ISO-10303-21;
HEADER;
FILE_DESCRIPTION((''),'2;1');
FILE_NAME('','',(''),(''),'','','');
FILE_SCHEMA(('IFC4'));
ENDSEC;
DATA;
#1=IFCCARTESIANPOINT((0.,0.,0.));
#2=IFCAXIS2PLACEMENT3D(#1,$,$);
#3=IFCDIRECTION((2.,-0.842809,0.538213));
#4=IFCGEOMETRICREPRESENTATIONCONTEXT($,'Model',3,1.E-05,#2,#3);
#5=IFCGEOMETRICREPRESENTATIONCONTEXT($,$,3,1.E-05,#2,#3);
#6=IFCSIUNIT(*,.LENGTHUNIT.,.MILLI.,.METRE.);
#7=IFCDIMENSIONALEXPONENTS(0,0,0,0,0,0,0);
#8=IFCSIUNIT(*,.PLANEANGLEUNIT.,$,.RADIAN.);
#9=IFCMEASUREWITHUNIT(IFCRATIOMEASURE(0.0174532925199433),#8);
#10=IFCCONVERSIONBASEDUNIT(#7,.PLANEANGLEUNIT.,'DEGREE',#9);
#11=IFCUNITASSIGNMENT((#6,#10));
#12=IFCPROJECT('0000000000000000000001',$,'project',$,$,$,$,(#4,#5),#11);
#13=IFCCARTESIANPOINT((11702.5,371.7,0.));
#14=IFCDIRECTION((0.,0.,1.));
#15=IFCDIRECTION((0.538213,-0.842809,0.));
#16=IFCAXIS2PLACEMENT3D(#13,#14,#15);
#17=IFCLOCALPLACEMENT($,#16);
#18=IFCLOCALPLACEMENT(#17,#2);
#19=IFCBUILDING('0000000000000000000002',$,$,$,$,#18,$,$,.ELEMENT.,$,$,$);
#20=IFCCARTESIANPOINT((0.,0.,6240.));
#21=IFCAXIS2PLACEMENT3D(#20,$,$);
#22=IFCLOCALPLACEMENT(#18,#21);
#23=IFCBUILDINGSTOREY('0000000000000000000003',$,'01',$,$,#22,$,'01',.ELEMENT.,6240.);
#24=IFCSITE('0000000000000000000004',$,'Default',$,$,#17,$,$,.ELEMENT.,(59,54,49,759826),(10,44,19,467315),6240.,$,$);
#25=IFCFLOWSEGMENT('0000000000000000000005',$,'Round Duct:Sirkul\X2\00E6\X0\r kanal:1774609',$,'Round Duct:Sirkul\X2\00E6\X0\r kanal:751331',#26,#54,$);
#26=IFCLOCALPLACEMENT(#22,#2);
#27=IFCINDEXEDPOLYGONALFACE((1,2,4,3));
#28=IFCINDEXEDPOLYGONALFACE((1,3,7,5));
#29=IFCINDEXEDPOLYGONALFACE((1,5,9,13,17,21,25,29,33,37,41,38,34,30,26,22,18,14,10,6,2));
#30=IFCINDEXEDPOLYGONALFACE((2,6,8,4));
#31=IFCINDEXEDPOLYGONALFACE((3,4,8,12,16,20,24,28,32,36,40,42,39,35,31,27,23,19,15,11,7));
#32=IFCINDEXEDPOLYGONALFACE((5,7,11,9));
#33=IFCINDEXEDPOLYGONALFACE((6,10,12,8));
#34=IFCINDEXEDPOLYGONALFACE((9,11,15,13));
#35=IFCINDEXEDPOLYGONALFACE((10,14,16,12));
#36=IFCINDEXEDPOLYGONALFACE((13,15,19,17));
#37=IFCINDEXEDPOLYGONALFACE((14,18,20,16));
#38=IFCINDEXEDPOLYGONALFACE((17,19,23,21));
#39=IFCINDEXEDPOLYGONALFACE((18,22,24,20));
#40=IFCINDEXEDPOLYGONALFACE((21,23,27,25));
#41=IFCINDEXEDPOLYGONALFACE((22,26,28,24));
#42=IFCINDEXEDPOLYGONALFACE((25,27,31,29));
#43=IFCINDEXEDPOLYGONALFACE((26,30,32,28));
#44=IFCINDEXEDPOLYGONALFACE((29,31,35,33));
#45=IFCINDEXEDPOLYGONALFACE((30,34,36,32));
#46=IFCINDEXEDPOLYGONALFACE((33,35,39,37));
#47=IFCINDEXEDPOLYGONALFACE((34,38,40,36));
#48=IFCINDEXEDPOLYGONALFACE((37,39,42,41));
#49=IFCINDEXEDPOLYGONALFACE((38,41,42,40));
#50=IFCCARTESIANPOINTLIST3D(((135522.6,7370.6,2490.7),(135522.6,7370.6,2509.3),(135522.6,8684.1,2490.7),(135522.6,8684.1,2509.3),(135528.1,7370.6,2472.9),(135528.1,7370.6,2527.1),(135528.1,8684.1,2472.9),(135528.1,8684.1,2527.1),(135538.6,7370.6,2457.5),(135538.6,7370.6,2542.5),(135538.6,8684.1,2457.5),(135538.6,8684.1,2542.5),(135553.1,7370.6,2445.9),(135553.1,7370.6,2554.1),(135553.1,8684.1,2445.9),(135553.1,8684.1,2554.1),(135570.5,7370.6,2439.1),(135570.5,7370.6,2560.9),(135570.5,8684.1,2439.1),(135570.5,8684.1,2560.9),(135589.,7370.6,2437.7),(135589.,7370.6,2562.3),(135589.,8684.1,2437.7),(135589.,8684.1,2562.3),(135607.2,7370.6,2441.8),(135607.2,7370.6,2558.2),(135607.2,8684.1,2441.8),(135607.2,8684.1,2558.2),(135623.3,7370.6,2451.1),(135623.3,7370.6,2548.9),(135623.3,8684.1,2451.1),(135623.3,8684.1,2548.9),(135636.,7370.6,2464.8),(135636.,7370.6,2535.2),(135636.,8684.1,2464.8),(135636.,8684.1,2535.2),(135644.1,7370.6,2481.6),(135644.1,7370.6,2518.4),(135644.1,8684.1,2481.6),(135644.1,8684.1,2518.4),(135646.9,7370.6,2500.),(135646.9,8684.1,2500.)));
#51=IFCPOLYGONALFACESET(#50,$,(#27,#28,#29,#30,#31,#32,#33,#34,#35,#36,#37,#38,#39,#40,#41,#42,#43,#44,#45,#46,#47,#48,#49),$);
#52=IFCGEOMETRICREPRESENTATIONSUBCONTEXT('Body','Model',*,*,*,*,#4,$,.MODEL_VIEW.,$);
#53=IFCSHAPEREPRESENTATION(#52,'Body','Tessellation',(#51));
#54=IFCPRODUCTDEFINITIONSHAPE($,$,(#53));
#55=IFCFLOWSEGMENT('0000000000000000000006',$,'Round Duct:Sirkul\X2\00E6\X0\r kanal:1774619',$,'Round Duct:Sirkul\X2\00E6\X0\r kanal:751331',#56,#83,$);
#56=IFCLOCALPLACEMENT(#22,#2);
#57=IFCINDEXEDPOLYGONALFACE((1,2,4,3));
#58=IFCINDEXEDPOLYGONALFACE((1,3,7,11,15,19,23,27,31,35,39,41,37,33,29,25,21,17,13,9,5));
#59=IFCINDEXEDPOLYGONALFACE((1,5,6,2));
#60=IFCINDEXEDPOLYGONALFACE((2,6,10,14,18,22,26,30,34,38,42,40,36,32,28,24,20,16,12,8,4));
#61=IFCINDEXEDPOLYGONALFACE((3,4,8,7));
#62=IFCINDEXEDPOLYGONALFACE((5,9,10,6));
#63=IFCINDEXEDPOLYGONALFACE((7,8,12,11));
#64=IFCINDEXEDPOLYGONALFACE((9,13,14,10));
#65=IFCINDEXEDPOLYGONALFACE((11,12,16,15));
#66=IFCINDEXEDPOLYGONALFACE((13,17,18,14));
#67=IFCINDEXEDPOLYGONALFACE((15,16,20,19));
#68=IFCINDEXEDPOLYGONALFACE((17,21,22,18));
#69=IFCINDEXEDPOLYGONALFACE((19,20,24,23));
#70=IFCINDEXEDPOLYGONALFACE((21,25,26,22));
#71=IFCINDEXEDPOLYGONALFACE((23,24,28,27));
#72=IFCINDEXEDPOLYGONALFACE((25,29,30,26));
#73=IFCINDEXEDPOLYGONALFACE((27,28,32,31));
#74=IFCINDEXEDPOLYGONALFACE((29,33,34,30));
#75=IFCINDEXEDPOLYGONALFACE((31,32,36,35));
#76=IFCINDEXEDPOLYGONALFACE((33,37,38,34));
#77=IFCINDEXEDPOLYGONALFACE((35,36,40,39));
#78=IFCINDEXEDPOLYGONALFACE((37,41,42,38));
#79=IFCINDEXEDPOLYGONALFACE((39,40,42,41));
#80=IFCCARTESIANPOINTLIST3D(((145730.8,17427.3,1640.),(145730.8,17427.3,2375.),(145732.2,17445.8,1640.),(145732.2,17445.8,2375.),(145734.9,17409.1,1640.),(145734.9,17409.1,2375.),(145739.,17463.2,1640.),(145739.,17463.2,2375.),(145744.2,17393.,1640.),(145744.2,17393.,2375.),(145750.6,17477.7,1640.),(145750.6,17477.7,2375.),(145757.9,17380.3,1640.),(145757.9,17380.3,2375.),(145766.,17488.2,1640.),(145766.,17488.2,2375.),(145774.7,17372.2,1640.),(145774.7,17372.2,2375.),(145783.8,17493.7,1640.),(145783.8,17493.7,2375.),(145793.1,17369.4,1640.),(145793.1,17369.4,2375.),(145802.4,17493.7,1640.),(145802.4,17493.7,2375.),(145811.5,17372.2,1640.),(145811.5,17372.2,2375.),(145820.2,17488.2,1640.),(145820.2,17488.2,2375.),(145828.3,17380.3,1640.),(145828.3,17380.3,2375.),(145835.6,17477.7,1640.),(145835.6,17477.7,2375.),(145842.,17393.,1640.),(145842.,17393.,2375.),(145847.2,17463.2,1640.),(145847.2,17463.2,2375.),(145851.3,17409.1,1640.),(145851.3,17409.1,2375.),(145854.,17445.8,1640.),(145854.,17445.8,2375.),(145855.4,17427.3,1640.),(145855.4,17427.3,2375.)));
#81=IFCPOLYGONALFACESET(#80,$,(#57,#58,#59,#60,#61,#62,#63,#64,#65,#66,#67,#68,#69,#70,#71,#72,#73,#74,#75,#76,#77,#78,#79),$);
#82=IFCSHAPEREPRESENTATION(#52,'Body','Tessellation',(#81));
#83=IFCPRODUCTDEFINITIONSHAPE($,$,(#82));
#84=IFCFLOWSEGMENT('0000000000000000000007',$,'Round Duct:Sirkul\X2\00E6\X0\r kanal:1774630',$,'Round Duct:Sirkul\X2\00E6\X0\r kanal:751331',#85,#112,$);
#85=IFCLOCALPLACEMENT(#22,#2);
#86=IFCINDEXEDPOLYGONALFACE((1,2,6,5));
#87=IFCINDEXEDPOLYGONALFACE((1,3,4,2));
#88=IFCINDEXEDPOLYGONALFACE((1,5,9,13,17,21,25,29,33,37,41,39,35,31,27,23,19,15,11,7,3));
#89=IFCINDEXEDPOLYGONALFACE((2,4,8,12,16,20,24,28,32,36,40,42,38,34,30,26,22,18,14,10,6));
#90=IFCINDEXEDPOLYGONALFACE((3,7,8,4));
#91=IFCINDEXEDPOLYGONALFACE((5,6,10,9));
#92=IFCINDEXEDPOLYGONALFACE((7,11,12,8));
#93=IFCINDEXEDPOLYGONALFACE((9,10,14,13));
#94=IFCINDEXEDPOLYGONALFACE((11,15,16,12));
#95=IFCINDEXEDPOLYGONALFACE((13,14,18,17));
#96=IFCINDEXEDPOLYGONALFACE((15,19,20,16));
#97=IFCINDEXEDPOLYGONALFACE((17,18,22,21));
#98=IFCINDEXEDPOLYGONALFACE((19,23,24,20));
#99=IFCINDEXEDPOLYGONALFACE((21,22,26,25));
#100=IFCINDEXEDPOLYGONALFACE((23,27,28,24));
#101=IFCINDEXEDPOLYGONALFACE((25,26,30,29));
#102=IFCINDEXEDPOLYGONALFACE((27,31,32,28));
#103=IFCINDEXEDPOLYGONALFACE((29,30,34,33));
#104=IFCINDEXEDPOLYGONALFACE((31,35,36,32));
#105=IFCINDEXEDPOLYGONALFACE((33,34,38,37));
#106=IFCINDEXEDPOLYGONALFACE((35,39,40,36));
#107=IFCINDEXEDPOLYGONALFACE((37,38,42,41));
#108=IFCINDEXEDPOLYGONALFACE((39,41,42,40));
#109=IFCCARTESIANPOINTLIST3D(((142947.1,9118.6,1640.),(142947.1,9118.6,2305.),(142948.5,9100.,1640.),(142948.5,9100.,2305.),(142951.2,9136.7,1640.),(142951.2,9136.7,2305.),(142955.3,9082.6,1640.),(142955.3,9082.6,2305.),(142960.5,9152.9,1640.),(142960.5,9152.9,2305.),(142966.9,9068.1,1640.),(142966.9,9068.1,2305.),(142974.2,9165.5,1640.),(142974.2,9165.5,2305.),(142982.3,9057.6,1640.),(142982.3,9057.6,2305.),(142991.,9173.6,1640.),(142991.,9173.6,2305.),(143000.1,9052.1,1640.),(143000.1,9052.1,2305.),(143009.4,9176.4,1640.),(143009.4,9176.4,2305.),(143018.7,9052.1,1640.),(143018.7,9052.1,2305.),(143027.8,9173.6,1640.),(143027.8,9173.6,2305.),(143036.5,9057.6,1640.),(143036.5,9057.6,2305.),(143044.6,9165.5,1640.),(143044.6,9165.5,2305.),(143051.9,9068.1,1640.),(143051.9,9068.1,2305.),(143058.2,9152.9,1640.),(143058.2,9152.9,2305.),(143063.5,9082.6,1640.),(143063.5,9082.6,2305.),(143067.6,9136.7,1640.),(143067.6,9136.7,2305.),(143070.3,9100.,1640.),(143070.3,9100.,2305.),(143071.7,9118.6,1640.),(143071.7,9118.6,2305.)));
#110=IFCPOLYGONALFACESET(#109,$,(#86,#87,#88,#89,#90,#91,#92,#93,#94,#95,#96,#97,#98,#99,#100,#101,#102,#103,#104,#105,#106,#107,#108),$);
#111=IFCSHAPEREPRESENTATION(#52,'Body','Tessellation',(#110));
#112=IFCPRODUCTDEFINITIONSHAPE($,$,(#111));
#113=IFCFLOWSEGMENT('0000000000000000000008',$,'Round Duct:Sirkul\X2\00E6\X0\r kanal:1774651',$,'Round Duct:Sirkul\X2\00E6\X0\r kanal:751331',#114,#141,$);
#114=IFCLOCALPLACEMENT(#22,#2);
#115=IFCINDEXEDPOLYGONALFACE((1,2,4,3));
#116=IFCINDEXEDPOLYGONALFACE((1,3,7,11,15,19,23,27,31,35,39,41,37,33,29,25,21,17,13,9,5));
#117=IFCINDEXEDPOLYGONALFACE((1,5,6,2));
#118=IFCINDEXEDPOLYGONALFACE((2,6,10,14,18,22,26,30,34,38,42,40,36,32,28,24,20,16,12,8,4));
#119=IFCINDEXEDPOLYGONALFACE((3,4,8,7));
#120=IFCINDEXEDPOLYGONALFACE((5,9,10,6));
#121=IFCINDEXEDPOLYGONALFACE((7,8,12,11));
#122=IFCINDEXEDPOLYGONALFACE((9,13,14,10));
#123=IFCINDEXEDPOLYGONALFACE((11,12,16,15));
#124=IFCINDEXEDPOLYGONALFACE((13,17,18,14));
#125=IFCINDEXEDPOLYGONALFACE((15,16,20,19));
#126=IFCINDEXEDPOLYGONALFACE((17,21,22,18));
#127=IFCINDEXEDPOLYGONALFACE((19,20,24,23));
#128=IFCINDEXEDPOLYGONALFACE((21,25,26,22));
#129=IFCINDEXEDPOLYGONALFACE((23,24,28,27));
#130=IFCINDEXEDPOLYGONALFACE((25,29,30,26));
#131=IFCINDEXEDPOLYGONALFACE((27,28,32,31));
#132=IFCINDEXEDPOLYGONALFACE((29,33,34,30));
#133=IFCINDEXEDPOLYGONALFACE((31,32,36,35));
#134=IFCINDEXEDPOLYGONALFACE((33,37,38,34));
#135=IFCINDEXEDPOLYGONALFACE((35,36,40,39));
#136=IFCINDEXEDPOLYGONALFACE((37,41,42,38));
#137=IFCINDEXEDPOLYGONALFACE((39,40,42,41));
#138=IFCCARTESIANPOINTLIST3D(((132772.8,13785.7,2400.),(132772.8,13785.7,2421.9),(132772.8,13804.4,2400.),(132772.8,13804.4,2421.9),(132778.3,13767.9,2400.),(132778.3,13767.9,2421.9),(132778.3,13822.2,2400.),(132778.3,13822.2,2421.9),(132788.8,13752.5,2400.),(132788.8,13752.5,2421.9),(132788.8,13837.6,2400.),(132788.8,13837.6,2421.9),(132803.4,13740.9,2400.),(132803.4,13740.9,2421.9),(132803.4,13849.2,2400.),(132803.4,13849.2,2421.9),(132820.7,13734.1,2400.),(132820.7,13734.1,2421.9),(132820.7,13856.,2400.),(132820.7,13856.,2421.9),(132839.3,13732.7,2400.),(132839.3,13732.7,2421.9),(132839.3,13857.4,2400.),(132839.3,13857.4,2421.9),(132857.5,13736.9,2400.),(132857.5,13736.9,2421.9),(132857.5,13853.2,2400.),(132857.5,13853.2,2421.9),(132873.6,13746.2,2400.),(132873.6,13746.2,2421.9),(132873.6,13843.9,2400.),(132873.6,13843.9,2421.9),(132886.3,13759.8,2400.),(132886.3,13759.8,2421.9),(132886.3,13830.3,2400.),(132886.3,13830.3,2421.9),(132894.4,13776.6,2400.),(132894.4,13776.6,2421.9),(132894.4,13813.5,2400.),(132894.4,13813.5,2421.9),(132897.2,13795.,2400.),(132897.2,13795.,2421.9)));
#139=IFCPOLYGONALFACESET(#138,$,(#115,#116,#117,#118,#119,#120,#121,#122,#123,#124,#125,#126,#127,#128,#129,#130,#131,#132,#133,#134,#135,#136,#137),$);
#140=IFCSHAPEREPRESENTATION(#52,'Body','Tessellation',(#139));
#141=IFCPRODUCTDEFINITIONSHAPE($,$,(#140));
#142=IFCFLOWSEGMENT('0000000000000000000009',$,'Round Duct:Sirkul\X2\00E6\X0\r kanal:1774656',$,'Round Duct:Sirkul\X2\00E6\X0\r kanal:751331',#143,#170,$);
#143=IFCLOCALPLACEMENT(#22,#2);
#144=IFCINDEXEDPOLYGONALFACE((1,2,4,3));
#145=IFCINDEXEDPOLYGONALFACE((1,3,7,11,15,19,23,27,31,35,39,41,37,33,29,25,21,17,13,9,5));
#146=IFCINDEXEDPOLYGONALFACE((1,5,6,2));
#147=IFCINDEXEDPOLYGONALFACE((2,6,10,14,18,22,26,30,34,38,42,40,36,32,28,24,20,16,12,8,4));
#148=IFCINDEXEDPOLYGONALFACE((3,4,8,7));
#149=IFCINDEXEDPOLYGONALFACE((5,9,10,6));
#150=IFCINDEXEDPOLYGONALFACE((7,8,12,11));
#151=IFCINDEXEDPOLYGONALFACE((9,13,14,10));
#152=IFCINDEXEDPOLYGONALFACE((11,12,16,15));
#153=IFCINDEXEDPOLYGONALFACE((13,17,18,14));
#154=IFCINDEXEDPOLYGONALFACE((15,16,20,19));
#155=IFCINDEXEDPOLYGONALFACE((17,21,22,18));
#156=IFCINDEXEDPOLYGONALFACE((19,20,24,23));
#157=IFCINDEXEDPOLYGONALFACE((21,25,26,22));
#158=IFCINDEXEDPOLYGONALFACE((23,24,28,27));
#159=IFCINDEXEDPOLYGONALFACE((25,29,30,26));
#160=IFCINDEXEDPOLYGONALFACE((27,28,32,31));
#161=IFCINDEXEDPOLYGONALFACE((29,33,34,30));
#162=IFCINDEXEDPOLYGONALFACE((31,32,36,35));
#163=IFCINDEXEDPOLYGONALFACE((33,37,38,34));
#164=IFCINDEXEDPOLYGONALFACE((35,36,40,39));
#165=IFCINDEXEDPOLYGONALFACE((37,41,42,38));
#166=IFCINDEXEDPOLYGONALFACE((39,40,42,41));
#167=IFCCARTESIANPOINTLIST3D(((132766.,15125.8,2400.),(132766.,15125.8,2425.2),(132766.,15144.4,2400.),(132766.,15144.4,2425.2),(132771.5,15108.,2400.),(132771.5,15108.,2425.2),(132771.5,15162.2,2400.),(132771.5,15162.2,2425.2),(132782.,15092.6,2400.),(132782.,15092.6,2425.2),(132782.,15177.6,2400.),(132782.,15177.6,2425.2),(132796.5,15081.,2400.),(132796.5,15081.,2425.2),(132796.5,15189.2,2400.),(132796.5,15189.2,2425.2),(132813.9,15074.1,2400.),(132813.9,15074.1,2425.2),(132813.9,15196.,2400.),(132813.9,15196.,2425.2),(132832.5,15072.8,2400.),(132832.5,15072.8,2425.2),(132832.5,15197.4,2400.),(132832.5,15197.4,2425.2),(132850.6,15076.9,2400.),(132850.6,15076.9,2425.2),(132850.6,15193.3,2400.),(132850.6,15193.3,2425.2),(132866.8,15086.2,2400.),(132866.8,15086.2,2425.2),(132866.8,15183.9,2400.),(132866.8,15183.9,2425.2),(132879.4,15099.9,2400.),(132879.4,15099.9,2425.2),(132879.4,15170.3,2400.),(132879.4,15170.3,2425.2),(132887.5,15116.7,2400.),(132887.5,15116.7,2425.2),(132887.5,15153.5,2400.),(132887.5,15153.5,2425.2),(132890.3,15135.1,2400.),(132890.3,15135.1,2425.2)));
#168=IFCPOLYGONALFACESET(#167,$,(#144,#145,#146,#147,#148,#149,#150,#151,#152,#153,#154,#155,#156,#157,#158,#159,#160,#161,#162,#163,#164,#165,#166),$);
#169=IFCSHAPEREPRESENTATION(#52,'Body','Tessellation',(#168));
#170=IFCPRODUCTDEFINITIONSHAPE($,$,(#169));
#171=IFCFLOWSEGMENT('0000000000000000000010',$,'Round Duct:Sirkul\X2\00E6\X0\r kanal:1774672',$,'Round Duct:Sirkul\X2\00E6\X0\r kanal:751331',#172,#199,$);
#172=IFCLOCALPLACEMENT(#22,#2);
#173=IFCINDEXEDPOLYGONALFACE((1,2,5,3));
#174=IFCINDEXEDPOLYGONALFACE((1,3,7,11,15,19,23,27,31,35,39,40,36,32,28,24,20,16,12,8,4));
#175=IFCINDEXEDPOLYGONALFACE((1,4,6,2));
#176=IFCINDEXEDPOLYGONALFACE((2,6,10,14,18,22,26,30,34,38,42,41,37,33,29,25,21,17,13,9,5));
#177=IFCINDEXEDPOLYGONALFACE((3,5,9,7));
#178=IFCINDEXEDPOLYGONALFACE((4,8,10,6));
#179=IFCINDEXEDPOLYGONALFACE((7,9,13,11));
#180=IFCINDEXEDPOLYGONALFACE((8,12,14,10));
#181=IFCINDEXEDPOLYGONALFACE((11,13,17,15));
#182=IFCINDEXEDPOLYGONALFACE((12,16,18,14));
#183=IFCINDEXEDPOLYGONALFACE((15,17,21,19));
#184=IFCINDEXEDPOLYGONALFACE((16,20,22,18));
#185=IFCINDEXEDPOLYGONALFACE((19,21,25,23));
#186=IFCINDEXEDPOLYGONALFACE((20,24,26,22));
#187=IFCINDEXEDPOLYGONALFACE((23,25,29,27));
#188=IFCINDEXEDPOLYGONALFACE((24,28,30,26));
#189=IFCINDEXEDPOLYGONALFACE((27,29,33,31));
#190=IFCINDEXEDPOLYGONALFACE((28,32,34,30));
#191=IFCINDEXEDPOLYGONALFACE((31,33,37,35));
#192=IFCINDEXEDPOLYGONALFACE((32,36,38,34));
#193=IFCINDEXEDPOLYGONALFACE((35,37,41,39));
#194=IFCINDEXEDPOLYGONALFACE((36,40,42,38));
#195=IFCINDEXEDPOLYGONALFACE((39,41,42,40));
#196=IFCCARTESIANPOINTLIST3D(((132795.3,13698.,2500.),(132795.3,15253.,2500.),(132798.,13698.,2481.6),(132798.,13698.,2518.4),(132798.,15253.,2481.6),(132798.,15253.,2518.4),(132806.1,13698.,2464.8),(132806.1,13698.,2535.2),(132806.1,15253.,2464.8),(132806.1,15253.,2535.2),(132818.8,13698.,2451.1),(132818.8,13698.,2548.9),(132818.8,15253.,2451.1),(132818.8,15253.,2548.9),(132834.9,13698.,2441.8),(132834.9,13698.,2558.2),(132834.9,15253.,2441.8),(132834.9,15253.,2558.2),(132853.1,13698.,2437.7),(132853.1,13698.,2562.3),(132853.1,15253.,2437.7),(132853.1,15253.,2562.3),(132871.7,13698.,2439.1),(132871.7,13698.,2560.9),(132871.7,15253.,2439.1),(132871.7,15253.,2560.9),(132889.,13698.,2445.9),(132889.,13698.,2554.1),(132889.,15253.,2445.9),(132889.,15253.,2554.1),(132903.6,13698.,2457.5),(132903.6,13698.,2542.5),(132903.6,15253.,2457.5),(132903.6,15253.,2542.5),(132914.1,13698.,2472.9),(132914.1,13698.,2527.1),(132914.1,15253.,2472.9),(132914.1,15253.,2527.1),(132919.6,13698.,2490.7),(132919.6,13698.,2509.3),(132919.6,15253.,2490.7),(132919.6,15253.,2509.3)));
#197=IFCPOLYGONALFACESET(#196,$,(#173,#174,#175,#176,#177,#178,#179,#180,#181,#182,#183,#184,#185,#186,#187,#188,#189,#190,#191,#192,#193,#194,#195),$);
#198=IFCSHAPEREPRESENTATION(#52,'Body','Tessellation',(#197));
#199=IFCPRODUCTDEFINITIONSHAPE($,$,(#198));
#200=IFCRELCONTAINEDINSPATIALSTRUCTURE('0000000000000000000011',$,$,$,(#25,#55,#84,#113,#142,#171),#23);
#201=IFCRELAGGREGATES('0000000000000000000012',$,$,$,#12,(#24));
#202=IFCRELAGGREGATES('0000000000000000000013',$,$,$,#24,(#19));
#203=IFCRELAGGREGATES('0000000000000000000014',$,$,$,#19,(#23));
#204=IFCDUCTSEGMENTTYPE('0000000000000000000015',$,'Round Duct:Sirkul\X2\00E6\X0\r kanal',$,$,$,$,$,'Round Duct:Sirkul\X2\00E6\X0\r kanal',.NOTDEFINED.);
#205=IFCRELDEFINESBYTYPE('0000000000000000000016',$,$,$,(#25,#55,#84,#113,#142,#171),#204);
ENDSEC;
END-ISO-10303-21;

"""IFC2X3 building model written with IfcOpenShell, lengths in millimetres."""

from ifc_helpers import new_model, entity, si_unit, converted_unit, direction, frame, frame_2d, origin, origin_2d_with_axis, place, context, subcontext, project, spatial, circle, extrude, type_object, element, save


model = new_model("IFC2X3")

# Units and contexts
model_context = context("Model", 3, precision=1e-05, world=origin(), true_north=direction((2.0, -0.842809, 0.538213)))
context_of_model = context(None, 3, precision=1e-05, world=origin(), true_north=direction((2.0, -0.842809, 0.538213)))
body_context = subcontext(model_context, "Body", "Model", "MODEL_VIEW")
ifc_project = project(units=[si_unit("LENGTHUNIT", "METRE", prefix="MILLI"), converted_unit("PLANEANGLEUNIT", "DEGREE", entity("IfcRatioMeasure", 0.0174532925199433), si_unit("PLANEANGLEUNIT", "RADIAN"), dimensions=[0, 0, 0, 0, 0, 0, 0])], contexts=[model_context, context_of_model])

# Site, building, storey
site_placement = place(None, frame((11702.5, 371.7, 0.0), z_axis=(0.0, 0.0, 1.0), x_axis=(0.538213, -0.842809, 0.0)))
site = spatial("IfcSite", under=ifc_project, at=site_placement, Name="Default", CompositionType="ELEMENT", RefLatitude=(59, 54, 49, 759826), RefLongitude=(10, 44, 19, 467315), RefElevation=6240.0)
building_placement = place(site_placement, origin())
building = spatial("IfcBuilding", under=site, at=building_placement, CompositionType="ELEMENT")
storey_placement = place(building_placement, frame((0.0, 0.0, 6240.0)))
storey = spatial("IfcBuildingStorey", under=building, at=storey_placement, Name="01", LongName="01", CompositionType="ELEMENT", Elevation=6240.0)

# Flow segments
duct_segment_type = type_object("IfcDuctSegmentType", Name="Round Duct:Sirkulær kanal", ElementType="Round Duct:Sirkulær kanal", PredefinedType="NOTDEFINED")
flow_segment_1_placement = place(storey_placement, origin())
element("IfcFlowSegment", 1, at=flow_segment_1_placement, inside=storey, type_object=duct_segment_type, Name="Round Duct:Sirkulær kanal:1774609", ObjectType="Round Duct:Sirkulær kanal:751331", context=body_context, shape_type="SweptSolid", body=[
    extrude(circle(Radius=62.5, at=frame_2d((0.0, 0.0), x_axis=(1.0, 0.0))), frame((135584.4, 7370.6, 2500.0), z_axis=(0.0, 1.0, 0.0), x_axis=(1.0, 0.0, 0.0)), (0.0, 0.0, 1.0), 1313.5),
])
flow_segment_2_placement = place(storey_placement, origin())
element("IfcFlowSegment", 2, at=flow_segment_2_placement, inside=storey, type_object=duct_segment_type, Name="Round Duct:Sirkulær kanal:1774619", ObjectType="Round Duct:Sirkulær kanal:751331", context=body_context, shape_type="SweptSolid", body=[
    extrude(circle(Radius=62.5, at=origin_2d_with_axis()), frame((145793.1, 17431.9, 1640.0), z_axis=(0.0, 0.0, 1.0), x_axis=(0.0, -1.0, 0.0)), (0.0, 0.0, 1.0), 735.0),
])
flow_segment_3_placement = place(storey_placement, origin())
element("IfcFlowSegment", 3, at=flow_segment_3_placement, inside=storey, type_object=duct_segment_type, Name="Round Duct:Sirkulær kanal:1774630", ObjectType="Round Duct:Sirkulær kanal:751331", context=body_context, shape_type="SweptSolid", body=[
    extrude(circle(Radius=62.5, at=origin_2d_with_axis()), frame((143009.4, 9113.9, 1640.0), z_axis=(0.0, 0.0, 1.0), x_axis=(0.0, 1.0, 0.0)), (0.0, 0.0, 1.0), 665.0),
])
flow_segment_4_placement = place(storey_placement, origin())
element("IfcFlowSegment", 4, at=flow_segment_4_placement, inside=storey, type_object=duct_segment_type, Name="Round Duct:Sirkulær kanal:1774651", ObjectType="Round Duct:Sirkulær kanal:751331", context=body_context, shape_type="SweptSolid", body=[
    extrude(circle(Radius=62.5, at=frame_2d((0.0, 0.0), x_axis=(1.0, 0.0))), frame((132834.7, 13795.0, 2400.0)), (0.0, 0.0, 1.0), 21.9),
])
flow_segment_5_placement = place(storey_placement, origin())
element("IfcFlowSegment", 5, at=flow_segment_5_placement, inside=storey, type_object=duct_segment_type, Name="Round Duct:Sirkulær kanal:1774656", ObjectType="Round Duct:Sirkulær kanal:751331", context=body_context, shape_type="SweptSolid", body=[
    extrude(circle(Radius=62.5, at=frame_2d((0.0, 0.0), x_axis=(1.0, 0.0))), frame((132827.8, 15135.1, 2400.0)), (0.0, 0.0, 1.0), 25.2),
])
flow_segment_6_placement = place(storey_placement, origin())
element("IfcFlowSegment", 6, at=flow_segment_6_placement, inside=storey, type_object=duct_segment_type, Name="Round Duct:Sirkulær kanal:1774672", ObjectType="Round Duct:Sirkulær kanal:751331", context=body_context, shape_type="SweptSolid", body=[
    extrude(circle(Radius=62.5, at=origin_2d_with_axis()), frame((132857.8, 13698.0, 2500.0), z_axis=(0.0, 1.0, 0.0), x_axis=(-1.0, 0.0, 0.0)), (0.0, 0.0, 1.0), 1555.0),
])

save(model, "model.ifc")
